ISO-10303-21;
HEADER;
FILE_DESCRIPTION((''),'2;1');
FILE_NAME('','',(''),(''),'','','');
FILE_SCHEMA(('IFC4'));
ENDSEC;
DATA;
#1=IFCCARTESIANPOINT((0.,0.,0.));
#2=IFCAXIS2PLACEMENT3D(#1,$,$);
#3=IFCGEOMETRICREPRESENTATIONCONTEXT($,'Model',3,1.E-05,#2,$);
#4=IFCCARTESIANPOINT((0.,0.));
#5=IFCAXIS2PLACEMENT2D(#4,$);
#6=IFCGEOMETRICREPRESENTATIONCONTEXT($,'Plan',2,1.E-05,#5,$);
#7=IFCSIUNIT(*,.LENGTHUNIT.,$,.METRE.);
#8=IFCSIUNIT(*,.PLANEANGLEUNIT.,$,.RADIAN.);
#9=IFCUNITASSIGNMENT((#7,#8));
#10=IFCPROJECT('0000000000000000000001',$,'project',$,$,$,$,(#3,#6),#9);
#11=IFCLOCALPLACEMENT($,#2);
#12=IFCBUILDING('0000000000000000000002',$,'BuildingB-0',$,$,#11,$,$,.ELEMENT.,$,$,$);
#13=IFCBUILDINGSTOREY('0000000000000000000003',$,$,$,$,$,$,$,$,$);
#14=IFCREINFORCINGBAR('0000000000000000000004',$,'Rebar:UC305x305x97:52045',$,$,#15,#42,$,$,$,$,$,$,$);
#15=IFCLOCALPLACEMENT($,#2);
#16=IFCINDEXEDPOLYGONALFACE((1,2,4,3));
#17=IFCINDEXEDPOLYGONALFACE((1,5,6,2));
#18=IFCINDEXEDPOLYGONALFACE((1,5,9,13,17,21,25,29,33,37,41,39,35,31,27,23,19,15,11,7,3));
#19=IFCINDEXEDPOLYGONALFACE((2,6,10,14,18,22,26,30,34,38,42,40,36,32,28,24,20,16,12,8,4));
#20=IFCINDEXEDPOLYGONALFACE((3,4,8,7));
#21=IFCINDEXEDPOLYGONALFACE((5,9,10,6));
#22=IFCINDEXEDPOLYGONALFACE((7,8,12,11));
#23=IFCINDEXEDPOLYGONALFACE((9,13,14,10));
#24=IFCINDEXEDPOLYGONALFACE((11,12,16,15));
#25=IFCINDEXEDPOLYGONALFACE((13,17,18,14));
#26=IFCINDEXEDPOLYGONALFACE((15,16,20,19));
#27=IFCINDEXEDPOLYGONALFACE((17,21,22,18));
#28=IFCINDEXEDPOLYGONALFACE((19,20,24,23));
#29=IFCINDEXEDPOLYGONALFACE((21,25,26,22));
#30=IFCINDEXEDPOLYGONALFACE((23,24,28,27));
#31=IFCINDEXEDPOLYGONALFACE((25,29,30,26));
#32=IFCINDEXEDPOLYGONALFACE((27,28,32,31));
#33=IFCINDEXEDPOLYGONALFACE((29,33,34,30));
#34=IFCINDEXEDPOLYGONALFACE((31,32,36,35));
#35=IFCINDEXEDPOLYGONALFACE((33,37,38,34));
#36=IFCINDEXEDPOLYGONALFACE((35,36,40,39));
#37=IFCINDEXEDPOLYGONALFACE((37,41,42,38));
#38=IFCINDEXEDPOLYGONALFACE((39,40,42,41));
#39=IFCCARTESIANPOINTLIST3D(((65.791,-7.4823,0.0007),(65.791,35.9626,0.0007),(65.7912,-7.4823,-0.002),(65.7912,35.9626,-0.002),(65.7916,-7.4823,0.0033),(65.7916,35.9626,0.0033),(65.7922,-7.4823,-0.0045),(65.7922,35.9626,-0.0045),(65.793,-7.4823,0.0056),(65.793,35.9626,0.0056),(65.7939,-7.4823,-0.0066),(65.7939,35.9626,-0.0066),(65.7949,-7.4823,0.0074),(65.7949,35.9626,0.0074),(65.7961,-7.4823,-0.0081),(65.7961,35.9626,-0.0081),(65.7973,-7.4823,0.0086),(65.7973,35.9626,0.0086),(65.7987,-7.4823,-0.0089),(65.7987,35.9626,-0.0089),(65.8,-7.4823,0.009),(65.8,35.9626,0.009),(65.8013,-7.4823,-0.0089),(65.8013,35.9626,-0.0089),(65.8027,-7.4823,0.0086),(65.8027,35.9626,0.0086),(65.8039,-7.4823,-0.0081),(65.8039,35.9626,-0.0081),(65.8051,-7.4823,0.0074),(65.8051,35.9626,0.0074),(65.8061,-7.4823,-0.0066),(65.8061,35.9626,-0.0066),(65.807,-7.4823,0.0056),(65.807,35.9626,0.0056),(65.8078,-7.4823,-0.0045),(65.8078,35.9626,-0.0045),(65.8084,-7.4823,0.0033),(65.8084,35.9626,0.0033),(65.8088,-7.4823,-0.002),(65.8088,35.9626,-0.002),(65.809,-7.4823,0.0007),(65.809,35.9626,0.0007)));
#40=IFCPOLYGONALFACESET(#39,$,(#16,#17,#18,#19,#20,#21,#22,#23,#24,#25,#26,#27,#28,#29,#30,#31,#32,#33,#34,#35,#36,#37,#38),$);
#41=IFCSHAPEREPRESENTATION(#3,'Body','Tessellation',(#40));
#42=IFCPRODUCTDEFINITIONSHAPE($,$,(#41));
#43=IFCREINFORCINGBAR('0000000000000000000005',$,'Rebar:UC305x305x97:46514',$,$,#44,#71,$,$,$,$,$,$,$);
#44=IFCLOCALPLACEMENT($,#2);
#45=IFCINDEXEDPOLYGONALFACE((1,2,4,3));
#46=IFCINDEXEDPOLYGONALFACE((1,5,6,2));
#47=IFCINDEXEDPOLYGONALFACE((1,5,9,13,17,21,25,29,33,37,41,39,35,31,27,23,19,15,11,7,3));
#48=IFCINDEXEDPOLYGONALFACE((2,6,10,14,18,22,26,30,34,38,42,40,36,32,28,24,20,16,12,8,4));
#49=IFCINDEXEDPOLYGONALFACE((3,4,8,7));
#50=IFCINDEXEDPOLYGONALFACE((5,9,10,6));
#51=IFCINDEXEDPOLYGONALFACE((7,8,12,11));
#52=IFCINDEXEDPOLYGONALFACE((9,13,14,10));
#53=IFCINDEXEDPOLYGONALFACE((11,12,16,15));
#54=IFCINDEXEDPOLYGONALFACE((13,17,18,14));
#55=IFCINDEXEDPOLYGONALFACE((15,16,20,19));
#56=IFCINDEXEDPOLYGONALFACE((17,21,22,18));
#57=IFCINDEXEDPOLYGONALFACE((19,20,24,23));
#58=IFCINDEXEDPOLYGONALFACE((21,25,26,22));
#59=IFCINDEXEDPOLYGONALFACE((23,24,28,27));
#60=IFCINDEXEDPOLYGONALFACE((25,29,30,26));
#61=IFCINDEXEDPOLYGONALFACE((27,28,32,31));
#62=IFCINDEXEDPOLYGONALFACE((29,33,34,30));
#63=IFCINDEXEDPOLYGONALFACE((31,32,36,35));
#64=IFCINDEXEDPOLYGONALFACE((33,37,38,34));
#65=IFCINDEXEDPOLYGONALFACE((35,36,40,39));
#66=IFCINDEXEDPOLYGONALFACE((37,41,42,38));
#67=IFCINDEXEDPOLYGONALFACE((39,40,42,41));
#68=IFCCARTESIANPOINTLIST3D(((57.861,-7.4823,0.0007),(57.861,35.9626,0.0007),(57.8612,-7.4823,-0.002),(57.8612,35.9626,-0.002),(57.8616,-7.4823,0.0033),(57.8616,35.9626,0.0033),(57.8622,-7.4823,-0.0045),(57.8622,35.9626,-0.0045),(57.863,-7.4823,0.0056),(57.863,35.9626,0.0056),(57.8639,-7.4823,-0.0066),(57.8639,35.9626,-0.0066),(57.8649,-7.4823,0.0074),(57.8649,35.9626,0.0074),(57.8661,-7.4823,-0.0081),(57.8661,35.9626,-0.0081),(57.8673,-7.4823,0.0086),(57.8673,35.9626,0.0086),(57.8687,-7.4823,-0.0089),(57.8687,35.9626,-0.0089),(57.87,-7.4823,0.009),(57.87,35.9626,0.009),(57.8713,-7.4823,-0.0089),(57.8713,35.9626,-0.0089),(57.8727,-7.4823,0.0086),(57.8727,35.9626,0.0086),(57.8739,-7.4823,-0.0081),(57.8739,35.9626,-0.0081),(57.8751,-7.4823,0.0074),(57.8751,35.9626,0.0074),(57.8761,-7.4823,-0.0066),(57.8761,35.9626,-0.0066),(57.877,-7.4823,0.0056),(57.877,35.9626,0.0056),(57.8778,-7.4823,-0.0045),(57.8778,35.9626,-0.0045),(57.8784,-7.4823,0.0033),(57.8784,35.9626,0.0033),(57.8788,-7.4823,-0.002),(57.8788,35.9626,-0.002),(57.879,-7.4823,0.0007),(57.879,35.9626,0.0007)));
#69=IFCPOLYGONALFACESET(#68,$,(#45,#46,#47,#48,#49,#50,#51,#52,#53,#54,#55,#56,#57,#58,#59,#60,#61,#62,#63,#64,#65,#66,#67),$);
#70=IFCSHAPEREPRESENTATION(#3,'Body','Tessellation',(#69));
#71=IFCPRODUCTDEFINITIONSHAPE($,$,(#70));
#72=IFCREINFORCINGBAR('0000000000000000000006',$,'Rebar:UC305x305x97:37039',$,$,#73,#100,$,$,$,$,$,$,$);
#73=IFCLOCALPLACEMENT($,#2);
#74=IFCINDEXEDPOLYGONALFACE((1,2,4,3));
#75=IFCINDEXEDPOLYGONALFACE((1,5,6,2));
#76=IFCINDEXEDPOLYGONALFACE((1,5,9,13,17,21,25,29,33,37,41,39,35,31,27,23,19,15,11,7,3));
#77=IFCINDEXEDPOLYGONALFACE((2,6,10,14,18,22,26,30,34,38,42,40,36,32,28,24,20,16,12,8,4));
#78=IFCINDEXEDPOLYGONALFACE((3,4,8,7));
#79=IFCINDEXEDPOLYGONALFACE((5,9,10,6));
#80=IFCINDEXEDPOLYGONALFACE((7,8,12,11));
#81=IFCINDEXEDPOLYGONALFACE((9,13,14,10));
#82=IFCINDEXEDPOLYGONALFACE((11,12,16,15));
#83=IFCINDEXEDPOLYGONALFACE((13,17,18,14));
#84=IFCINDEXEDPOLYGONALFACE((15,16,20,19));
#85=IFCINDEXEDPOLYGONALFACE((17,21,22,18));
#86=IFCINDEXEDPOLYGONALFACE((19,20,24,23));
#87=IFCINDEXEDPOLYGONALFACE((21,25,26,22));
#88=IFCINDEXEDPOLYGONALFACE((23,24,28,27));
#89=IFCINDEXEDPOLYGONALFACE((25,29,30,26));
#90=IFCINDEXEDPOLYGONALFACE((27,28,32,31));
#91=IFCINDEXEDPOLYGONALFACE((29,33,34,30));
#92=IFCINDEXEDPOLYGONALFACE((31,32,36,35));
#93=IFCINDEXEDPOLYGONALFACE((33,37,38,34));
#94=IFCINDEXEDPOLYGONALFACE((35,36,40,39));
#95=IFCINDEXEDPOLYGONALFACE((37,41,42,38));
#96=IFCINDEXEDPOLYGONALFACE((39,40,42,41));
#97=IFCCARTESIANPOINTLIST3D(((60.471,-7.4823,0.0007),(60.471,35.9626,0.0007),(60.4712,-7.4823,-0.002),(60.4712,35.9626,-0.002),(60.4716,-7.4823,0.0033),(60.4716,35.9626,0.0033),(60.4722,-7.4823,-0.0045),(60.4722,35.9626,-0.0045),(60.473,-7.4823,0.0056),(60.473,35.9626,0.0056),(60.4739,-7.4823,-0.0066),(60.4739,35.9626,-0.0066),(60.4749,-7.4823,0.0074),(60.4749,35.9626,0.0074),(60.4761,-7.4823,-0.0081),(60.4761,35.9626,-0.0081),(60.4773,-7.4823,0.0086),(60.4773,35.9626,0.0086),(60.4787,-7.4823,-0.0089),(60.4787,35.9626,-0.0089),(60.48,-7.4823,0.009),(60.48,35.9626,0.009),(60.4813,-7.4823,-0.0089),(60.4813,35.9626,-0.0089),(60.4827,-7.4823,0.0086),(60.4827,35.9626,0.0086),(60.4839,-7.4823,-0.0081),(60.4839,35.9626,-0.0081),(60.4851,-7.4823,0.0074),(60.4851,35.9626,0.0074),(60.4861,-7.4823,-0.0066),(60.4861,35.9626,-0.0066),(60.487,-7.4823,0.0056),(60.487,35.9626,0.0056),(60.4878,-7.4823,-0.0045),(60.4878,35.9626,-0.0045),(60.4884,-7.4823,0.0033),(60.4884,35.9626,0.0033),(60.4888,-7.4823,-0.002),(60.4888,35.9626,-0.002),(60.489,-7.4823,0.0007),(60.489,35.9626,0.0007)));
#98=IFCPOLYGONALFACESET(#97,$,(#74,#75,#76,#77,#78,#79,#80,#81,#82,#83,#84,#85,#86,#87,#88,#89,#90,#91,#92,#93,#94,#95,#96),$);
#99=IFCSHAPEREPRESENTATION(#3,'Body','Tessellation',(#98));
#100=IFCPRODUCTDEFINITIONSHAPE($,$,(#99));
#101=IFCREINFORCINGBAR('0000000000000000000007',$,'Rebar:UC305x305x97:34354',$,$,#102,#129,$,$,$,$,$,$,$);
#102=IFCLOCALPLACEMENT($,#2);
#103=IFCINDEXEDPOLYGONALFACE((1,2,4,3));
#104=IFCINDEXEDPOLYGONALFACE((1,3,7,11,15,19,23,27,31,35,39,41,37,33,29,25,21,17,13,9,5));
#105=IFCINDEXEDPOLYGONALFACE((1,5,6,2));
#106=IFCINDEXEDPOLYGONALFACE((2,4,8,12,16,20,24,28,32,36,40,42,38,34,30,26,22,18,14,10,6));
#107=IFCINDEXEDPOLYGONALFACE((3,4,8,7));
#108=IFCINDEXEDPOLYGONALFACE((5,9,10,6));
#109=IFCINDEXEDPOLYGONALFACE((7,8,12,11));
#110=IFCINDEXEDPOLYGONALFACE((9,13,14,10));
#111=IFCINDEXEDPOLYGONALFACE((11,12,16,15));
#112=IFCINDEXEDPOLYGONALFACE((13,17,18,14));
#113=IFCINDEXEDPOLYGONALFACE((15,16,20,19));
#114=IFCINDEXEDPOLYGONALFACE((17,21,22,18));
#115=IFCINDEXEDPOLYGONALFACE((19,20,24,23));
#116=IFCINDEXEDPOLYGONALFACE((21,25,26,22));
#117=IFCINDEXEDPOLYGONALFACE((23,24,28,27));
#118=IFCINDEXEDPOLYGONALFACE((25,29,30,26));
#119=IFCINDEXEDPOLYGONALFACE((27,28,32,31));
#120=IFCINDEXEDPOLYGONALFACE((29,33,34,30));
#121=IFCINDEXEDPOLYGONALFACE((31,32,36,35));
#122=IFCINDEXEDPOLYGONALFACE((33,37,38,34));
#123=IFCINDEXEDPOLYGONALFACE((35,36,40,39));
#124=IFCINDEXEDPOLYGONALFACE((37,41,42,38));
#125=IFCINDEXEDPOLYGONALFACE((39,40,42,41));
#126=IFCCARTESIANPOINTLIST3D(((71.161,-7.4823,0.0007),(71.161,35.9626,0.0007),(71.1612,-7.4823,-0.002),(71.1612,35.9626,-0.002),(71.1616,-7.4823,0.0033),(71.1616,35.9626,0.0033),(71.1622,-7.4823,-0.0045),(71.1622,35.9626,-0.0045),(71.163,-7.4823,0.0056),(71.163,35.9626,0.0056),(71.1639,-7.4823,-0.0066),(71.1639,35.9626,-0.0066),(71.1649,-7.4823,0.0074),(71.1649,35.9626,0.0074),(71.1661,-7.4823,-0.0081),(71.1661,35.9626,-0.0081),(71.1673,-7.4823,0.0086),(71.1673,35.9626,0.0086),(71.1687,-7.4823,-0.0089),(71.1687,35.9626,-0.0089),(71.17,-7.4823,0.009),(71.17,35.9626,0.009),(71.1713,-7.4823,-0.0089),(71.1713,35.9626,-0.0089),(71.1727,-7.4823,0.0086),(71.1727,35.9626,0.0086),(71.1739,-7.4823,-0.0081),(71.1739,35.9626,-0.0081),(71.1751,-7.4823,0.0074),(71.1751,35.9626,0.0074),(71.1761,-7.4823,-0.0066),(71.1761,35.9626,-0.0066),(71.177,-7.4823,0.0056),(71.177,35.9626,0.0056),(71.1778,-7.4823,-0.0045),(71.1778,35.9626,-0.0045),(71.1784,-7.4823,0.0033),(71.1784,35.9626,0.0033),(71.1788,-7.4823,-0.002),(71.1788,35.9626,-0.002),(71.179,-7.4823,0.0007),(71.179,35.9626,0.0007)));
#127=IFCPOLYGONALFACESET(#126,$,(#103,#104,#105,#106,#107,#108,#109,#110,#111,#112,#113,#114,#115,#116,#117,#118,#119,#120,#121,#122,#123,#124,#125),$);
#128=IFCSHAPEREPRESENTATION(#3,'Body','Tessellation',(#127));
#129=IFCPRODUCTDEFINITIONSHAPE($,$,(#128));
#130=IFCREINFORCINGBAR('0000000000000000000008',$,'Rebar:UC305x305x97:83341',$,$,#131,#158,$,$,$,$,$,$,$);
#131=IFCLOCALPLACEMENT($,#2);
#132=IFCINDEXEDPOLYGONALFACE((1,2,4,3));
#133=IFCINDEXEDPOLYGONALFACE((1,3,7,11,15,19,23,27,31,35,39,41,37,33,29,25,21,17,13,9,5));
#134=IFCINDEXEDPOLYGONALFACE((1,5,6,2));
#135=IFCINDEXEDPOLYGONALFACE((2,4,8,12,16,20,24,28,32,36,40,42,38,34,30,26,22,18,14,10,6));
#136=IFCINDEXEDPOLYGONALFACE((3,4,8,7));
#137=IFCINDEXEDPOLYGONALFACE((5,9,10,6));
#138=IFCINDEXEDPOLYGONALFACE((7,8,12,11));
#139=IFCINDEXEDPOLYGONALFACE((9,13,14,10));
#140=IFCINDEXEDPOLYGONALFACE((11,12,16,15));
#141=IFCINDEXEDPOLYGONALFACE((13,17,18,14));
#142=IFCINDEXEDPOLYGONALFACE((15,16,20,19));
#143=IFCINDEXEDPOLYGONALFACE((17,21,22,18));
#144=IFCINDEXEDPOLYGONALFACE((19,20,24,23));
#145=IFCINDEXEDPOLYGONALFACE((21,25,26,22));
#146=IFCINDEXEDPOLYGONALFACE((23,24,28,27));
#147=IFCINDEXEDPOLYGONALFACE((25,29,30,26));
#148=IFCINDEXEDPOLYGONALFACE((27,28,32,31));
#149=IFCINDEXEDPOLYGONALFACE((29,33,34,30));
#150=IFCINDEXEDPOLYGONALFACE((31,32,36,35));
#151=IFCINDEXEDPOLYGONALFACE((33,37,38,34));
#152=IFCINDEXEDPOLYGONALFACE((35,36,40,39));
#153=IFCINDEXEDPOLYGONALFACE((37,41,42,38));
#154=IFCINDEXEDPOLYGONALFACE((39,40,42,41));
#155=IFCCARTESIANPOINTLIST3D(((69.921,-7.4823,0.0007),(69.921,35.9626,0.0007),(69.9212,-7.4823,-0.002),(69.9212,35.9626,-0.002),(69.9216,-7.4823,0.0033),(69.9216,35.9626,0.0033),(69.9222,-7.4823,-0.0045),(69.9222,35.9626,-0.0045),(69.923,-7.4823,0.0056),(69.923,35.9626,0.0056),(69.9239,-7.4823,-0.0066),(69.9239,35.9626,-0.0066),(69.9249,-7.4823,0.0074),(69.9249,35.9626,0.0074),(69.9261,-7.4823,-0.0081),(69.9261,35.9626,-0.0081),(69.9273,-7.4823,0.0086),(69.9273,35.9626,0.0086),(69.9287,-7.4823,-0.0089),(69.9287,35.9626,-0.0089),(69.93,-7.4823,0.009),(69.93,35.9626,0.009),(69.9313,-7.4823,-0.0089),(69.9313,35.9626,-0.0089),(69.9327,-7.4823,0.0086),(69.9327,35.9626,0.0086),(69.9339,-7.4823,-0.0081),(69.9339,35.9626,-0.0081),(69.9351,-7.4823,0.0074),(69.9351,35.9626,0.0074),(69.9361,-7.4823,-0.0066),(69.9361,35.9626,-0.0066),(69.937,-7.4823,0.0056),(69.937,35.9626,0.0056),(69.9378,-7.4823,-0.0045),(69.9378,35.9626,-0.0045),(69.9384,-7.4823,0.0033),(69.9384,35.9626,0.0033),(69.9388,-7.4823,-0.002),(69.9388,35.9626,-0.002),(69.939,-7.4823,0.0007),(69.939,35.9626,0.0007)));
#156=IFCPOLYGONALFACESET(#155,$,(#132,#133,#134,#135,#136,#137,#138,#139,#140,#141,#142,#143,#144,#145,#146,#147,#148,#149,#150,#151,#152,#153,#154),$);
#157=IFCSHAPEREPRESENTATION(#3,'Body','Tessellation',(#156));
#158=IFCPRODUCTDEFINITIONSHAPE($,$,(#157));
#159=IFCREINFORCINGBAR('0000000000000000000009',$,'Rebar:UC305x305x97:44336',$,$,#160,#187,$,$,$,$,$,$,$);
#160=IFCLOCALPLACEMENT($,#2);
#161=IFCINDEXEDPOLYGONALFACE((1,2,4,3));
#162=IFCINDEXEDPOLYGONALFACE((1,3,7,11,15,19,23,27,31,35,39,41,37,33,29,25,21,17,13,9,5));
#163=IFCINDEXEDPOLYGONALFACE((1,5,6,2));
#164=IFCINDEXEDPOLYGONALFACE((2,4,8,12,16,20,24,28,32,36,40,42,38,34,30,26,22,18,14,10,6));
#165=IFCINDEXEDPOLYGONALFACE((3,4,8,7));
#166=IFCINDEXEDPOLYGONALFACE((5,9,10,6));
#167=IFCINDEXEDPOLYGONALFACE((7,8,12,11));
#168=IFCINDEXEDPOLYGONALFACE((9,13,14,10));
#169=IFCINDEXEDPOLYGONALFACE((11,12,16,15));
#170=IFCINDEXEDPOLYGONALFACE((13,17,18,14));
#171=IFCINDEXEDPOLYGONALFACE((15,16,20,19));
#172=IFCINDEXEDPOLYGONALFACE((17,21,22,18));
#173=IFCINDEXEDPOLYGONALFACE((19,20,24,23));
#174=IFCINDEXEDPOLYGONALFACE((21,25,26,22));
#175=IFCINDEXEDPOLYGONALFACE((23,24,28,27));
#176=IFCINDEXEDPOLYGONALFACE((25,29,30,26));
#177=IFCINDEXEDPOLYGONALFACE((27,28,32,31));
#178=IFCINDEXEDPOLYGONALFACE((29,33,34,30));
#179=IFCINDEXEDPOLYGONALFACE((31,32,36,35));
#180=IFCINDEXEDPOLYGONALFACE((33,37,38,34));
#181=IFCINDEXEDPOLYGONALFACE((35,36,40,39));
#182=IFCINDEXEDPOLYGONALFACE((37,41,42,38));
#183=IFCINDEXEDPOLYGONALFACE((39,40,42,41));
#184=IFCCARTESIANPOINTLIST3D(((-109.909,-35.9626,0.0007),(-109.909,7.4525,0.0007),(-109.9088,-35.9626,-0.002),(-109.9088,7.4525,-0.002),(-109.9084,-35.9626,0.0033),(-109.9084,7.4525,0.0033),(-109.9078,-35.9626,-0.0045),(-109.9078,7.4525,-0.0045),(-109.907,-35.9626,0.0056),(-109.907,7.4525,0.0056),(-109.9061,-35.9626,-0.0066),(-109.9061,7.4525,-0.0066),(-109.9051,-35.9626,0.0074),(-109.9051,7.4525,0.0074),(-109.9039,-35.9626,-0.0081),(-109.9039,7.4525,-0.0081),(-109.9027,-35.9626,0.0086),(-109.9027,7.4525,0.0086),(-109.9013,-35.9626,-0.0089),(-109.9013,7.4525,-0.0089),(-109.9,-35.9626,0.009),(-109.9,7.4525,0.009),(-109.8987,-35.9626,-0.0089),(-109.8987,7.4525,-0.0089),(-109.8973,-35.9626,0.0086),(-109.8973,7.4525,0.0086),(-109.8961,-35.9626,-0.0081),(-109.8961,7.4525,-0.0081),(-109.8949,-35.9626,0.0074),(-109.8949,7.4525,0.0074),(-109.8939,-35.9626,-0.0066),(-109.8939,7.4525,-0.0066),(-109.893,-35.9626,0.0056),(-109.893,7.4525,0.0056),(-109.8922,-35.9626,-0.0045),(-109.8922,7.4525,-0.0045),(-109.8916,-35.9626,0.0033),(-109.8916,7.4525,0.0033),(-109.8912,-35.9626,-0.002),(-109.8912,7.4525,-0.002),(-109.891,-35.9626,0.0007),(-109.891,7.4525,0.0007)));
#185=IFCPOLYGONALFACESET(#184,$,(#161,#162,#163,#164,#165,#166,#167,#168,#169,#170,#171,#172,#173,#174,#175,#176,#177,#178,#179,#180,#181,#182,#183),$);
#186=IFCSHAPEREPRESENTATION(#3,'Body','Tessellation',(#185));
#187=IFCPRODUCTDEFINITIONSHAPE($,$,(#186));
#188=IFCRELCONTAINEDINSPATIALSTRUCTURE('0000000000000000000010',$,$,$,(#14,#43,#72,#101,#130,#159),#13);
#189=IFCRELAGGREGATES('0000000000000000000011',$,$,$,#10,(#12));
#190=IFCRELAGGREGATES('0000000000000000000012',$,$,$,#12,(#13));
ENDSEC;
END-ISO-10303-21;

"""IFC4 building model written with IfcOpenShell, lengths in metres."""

from ifc_helpers import new_model, entity, si_unit, origin, origin_2d, place, context, project, spatial, element, save


model = new_model("IFC4")

# Units and contexts
model_context = context("Model", 3, precision=1e-05, world=origin())
plan_context = context("Plan", 2, precision=1e-05, world=origin_2d())
ifc_project = project(units=[si_unit("LENGTHUNIT", "METRE"), si_unit("PLANEANGLEUNIT", "RADIAN")], contexts=[model_context, plan_context])

# Building, storey
building_placement = place(None, origin())
building = spatial("IfcBuilding", under=ifc_project, at=building_placement, Name="BuildingB-0", CompositionType="ELEMENT")
storey = spatial("IfcBuildingStorey", under=building)

# Reinforcing bars
element("IfcReinforcingBar", 1, inside=storey, Name="Rebar:UC305x305x97:52045", context=model_context, shape_type="SweptSolid", body=[
    entity("IfcSurfaceCurveSweptAreaSolid", entity("IfcCircleProfileDef", "AREA", None, None, 0.009), None, entity("IfcPolyline", [entity("IfcCartesianPoint", [65.8, -7.4823, 0.0]), entity("IfcCartesianPoint", [65.8, 35.9626, 0.0])]), None, None, entity("IfcPlane", entity("IfcAxis2Placement3D", entity("IfcCartesianPoint", [65.8, -7.4823, 0.0]), entity("IfcDirection", [0.0, 0.0, 1.0]), entity("IfcDirection", [1.0, 0.0, 0.0])))),
])
element("IfcReinforcingBar", 2, inside=storey, Name="Rebar:UC305x305x97:46514", context=model_context, shape_type="SweptSolid", body=[
    entity("IfcSurfaceCurveSweptAreaSolid", entity("IfcCircleProfileDef", "AREA", None, None, 0.009), None, entity("IfcPolyline", [entity("IfcCartesianPoint", [57.87, -7.4823, 0.0]), entity("IfcCartesianPoint", [57.87, 35.9626, 0.0])]), None, None, entity("IfcPlane", entity("IfcAxis2Placement3D", entity("IfcCartesianPoint", [57.87, -7.4823, 0.0]), entity("IfcDirection", [0.0, 0.0, 1.0]), entity("IfcDirection", [1.0, 0.0, 0.0])))),
])
element("IfcReinforcingBar", 3, inside=storey, Name="Rebar:UC305x305x97:37039", context=model_context, shape_type="SweptSolid", body=[
    entity("IfcSurfaceCurveSweptAreaSolid", entity("IfcCircleProfileDef", "AREA", None, None, 0.009), None, entity("IfcPolyline", [entity("IfcCartesianPoint", [60.48, -7.4823, 0.0]), entity("IfcCartesianPoint", [60.48, 35.9626, 0.0])]), None, None, entity("IfcPlane", entity("IfcAxis2Placement3D", entity("IfcCartesianPoint", [60.48, -7.4823, 0.0]), entity("IfcDirection", [0.0, 0.0, 1.0]), entity("IfcDirection", [1.0, 0.0, 0.0])))),
])
element("IfcReinforcingBar", 4, inside=storey, Name="Rebar:UC305x305x97:34354", context=model_context, shape_type="SweptSolid", body=[
    entity("IfcSurfaceCurveSweptAreaSolid", entity("IfcCircleProfileDef", "AREA", None, None, 0.009), None, entity("IfcPolyline", [entity("IfcCartesianPoint", [71.17, 35.9626, 0.0]), entity("IfcCartesianPoint", [71.17, -7.4823, 0.0])]), None, None, entity("IfcPlane", entity("IfcAxis2Placement3D", entity("IfcCartesianPoint", [71.17, 35.9626, 0.0]), entity("IfcDirection", [0.0, 0.0, 1.0]), entity("IfcDirection", [1.0, 0.0, 0.0])))),
])
element("IfcReinforcingBar", 5, inside=storey, Name="Rebar:UC305x305x97:83341", context=model_context, shape_type="SweptSolid", body=[
    entity("IfcSurfaceCurveSweptAreaSolid", entity("IfcCircleProfileDef", "AREA", None, None, 0.009), None, entity("IfcPolyline", [entity("IfcCartesianPoint", [69.93, 35.9626, 0.0]), entity("IfcCartesianPoint", [69.93, -7.4823, 0.0])]), None, None, entity("IfcPlane", entity("IfcAxis2Placement3D", entity("IfcCartesianPoint", [69.93, 35.9626, 0.0]), entity("IfcDirection", [0.0, 0.0, 1.0]), entity("IfcDirection", [1.0, 0.0, 0.0])))),
])
element("IfcReinforcingBar", 6, inside=storey, Name="Rebar:UC305x305x97:44336", context=model_context, shape_type="SweptSolid", body=[
    entity("IfcSurfaceCurveSweptAreaSolid", entity("IfcCircleProfileDef", "AREA", None, None, 0.009), None, entity("IfcPolyline", [entity("IfcCartesianPoint", [109.9, 35.9626, 0.0]), entity("IfcCartesianPoint", [109.9, -7.4525, 0.0])]), None, None, entity("IfcPlane", entity("IfcAxis2Placement3D", entity("IfcCartesianPoint", [109.9, 35.9626, 0.0]), entity("IfcDirection", [0.0, 0.0, 1.0]), entity("IfcDirection", [1.0, 0.0, 0.0])))),
])

save(model, "model.ifc")
